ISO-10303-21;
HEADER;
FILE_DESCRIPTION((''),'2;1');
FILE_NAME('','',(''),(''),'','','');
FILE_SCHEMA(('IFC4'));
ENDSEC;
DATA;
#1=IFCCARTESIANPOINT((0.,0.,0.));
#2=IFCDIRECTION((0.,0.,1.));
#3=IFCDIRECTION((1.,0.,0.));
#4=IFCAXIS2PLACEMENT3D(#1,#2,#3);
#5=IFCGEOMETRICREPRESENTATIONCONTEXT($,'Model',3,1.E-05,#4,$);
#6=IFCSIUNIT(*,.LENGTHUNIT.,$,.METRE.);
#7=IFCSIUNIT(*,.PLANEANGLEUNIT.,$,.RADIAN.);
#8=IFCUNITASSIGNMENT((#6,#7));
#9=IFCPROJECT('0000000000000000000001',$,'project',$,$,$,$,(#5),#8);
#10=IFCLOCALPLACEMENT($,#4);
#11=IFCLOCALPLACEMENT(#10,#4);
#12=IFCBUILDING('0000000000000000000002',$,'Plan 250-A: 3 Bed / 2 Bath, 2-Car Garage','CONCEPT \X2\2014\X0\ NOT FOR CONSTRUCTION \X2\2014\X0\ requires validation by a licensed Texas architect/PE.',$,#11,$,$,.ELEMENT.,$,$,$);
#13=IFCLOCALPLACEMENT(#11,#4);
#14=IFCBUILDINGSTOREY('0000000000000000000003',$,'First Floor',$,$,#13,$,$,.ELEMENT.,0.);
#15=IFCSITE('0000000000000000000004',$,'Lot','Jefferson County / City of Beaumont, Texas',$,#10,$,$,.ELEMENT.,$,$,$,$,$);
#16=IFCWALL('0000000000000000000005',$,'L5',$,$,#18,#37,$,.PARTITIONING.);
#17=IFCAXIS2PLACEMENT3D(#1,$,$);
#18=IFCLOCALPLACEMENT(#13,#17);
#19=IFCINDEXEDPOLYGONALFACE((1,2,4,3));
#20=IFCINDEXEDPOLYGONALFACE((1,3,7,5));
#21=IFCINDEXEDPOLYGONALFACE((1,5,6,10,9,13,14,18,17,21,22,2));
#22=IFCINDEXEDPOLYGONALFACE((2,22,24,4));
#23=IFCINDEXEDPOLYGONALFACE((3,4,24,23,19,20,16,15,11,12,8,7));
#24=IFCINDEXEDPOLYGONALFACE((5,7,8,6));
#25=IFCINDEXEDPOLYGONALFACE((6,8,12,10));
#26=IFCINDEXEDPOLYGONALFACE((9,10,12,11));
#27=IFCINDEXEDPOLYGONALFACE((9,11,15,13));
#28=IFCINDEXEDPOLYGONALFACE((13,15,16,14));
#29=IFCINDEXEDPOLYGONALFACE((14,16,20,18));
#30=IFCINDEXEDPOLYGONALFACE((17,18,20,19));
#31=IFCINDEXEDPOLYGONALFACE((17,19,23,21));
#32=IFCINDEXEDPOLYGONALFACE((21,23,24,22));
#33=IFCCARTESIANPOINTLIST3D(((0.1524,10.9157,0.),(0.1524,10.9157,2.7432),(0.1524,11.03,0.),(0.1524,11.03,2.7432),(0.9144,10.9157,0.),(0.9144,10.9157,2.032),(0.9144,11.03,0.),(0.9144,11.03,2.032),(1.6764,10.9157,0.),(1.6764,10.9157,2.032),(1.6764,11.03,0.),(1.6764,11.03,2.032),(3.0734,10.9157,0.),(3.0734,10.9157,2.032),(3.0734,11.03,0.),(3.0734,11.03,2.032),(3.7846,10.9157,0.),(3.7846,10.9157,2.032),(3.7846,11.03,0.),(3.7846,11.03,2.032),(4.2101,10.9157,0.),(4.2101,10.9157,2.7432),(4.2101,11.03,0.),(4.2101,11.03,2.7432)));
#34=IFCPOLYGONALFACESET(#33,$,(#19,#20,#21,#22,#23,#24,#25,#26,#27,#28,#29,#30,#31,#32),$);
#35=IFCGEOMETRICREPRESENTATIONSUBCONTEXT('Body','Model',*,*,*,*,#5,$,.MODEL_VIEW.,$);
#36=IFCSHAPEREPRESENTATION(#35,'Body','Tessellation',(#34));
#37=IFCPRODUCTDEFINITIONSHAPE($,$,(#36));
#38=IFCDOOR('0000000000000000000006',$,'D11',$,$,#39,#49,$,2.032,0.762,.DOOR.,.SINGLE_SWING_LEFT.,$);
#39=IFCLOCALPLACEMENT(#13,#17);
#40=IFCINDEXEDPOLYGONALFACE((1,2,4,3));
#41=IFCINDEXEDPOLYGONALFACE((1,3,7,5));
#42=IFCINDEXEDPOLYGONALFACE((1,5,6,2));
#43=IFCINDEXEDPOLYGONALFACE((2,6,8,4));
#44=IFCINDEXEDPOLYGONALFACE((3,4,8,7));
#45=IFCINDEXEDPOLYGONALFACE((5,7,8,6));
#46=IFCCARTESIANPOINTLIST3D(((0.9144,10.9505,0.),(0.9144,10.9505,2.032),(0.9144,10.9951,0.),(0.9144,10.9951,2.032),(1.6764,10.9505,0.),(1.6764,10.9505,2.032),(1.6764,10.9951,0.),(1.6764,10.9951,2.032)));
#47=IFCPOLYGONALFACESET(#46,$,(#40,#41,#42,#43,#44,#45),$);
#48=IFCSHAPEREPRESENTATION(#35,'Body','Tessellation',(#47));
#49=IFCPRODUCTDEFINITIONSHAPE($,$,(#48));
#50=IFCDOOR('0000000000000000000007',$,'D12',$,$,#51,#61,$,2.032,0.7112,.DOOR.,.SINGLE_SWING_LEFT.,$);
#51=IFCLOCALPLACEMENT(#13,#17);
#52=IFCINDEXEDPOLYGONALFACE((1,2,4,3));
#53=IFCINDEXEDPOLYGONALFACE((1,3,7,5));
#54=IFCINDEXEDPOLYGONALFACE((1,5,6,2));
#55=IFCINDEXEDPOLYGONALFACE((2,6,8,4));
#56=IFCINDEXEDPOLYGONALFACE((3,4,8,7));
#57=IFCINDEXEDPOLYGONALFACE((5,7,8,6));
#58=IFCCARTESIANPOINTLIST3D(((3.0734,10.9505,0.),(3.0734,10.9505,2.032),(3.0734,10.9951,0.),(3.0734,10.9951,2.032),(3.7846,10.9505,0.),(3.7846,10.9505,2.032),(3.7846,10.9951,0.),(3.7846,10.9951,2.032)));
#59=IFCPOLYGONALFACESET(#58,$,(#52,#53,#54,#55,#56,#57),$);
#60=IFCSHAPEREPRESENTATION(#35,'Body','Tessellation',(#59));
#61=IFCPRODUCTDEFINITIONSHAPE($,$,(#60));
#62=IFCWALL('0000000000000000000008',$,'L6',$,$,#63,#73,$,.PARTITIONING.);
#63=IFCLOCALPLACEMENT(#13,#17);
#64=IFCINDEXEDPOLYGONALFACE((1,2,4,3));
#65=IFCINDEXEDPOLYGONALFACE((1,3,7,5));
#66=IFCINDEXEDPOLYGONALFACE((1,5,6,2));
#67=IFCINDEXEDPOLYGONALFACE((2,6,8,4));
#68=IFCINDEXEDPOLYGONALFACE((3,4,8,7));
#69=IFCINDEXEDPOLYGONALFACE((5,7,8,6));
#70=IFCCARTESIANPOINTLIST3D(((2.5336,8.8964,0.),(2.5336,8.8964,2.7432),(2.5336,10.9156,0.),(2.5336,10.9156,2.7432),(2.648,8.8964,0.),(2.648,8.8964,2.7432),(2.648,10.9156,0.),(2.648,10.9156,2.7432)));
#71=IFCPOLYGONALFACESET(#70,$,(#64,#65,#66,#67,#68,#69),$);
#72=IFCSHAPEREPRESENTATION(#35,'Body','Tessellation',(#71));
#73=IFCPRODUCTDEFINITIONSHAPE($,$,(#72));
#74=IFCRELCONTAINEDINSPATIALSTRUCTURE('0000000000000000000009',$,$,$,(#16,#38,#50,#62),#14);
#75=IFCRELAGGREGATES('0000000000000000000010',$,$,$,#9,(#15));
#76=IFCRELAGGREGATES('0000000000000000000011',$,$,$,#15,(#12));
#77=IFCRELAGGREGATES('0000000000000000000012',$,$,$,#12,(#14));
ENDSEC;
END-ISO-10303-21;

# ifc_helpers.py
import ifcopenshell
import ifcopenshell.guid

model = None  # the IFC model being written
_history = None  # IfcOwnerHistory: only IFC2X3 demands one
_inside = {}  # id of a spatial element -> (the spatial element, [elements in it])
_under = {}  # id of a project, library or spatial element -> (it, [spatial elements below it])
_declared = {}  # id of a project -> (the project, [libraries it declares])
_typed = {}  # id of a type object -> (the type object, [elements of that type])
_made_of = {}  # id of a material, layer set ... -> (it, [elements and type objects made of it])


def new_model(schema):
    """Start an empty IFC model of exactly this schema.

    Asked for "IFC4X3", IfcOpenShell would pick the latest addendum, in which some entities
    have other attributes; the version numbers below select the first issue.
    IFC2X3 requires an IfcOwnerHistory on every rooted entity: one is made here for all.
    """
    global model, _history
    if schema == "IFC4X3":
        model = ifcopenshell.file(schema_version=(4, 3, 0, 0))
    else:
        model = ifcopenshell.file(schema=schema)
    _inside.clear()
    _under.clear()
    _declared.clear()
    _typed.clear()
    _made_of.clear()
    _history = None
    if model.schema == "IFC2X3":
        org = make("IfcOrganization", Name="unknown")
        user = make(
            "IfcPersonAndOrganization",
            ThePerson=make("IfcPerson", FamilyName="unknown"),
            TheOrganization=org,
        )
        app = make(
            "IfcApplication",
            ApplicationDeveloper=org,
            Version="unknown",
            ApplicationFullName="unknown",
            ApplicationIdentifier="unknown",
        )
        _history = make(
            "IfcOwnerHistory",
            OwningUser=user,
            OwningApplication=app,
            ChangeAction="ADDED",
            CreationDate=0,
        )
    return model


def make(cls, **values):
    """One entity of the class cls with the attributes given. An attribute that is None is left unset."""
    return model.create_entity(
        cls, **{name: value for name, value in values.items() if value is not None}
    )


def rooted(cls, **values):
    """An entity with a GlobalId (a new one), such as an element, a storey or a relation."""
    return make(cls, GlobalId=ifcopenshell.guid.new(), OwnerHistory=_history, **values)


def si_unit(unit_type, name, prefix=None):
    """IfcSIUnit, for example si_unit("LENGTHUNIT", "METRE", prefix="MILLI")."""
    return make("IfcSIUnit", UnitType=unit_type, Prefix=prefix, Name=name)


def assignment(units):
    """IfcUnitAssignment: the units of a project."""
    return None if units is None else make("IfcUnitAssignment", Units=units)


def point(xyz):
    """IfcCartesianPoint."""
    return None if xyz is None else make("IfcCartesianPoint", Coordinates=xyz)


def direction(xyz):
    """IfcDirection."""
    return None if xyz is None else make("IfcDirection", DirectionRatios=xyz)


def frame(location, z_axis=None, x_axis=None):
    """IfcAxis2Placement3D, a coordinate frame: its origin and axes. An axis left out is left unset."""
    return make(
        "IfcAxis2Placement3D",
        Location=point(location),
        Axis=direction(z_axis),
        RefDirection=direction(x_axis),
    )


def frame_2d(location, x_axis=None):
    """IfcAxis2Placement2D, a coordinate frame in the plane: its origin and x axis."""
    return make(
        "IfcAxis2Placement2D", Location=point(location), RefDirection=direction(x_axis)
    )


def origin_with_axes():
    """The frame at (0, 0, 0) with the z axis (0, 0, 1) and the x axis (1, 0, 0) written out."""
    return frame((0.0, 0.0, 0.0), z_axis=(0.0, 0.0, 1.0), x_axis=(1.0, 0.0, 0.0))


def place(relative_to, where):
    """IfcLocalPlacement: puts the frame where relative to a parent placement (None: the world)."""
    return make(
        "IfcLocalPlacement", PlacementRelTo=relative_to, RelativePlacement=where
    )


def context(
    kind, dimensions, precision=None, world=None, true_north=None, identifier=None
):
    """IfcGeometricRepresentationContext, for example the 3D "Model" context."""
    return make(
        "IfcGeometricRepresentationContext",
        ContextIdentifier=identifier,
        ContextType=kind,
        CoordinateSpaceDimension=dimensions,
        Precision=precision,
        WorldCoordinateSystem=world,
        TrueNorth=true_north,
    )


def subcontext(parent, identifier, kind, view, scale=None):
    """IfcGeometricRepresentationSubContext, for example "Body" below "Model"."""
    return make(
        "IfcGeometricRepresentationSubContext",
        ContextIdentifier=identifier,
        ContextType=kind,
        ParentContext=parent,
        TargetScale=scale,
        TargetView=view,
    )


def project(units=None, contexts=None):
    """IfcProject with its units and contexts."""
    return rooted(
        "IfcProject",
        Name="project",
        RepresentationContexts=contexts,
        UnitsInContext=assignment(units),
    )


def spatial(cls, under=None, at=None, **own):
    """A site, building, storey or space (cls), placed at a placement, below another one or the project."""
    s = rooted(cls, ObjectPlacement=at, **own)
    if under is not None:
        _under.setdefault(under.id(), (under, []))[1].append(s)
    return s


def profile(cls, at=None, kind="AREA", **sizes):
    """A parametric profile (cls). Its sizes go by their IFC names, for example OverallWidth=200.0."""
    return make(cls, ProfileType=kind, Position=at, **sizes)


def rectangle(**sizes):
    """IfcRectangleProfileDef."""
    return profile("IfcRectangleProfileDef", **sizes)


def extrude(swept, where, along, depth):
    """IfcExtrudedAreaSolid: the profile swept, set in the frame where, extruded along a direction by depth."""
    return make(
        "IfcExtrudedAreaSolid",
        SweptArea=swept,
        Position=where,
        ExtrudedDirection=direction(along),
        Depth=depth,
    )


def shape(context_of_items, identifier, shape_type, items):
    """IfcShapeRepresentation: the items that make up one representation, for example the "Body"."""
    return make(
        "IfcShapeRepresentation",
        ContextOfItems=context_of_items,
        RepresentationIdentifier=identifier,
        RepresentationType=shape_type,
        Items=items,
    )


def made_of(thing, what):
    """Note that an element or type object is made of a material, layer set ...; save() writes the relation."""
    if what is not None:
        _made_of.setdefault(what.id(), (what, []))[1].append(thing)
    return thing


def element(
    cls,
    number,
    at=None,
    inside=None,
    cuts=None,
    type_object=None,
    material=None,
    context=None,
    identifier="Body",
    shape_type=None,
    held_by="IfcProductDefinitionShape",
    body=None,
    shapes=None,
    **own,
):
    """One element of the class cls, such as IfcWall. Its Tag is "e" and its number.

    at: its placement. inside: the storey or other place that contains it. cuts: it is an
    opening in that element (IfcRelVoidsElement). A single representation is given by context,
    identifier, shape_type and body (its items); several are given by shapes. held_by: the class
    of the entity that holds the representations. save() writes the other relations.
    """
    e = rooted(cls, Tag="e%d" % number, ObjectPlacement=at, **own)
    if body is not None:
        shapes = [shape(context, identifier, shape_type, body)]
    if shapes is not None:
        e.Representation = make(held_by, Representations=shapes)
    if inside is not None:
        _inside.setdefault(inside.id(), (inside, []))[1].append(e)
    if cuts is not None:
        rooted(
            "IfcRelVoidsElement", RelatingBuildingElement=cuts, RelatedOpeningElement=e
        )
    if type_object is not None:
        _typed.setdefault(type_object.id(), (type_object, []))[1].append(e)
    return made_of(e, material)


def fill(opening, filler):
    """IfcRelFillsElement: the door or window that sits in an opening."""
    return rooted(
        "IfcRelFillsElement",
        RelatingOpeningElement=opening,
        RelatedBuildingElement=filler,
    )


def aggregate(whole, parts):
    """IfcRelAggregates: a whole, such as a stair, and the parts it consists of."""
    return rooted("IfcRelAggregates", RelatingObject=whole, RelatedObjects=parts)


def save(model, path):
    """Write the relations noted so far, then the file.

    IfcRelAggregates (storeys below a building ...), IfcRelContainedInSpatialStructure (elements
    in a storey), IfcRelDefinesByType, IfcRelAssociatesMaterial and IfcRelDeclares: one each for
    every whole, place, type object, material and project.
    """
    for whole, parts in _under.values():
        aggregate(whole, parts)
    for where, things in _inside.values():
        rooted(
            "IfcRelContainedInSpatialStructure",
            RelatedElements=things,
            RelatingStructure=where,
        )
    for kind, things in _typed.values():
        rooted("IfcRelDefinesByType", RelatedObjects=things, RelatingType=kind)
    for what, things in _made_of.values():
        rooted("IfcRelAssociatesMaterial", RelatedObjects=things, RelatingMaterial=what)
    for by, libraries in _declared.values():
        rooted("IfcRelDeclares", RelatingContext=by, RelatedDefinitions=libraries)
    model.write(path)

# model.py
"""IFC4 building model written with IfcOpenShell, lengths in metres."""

from ifc_helpers import new_model, si_unit, frame, frame_2d, origin_with_axes, place, context, subcontext, project, spatial, rectangle, extrude, element, fill, save


model = new_model("IFC4")

# Units and contexts
model_context = context("Model", 3, precision=1e-05, world=origin_with_axes())
body_context = subcontext(model_context, "Body", "Model", "MODEL_VIEW")
ifc_project = project(units=[si_unit("LENGTHUNIT", "METRE"), si_unit("PLANEANGLEUNIT", "RADIAN")], contexts=[model_context])

# Site, building, storey
site_placement = place(None, origin_with_axes())
site = spatial("IfcSite", under=ifc_project, at=site_placement, Name="Lot", Description="Jefferson County / City of Beaumont, Texas", CompositionType="ELEMENT")
building_placement = place(site_placement, origin_with_axes())
building = spatial("IfcBuilding", under=site, at=building_placement, Name="Plan 250-A: 3 Bed / 2 Bath, 2-Car Garage", Description="CONCEPT — NOT FOR CONSTRUCTION — requires validation by a licensed Texas architect/PE.", CompositionType="ELEMENT")
storey_placement = place(building_placement, origin_with_axes())
storey = spatial("IfcBuildingStorey", under=building, at=storey_placement, Name="First Floor", CompositionType="ELEMENT", Elevation=0.0)

# Wall, openings, doors
wall_1_placement = place(storey_placement, frame((0.1524, 10.9728, 0.0), z_axis=(0.0, 0.0, 1.0), x_axis=(1.0, 0.0, 0.0)))
wall_1 = element("IfcWall", 1, at=wall_1_placement, inside=storey, Name="L5", PredefinedType="PARTITIONING", context=body_context, shape_type="SweptSolid", body=[
    extrude(rectangle(XDim=4.0577, YDim=0.1143, at=frame_2d((2.0288, 0.0), x_axis=(1.0, 0.0))), origin_with_axes(), (0.0, 0.0, 1.0), 2.7432),
])
opening_1_placement = place(wall_1_placement, frame((0.762, 0.0, 0.0), z_axis=(0.0, 0.0, 1.0), x_axis=(1.0, 0.0, 0.0)))
opening_1 = element("IfcOpeningElement", 2, at=opening_1_placement, cuts=wall_1, PredefinedType="OPENING", context=body_context, shape_type="SweptSolid", body=[
    extrude(rectangle(XDim=0.762, YDim=0.1448, at=frame_2d((0.381, 0.0), x_axis=(1.0, 0.0))), origin_with_axes(), (0.0, 0.0, 1.0), 2.032),
])
opening_2_placement = place(wall_1_placement, frame((2.921, 0.0, 0.0), z_axis=(0.0, 0.0, 1.0), x_axis=(1.0, 0.0, 0.0)))
opening_2 = element("IfcOpeningElement", 3, at=opening_2_placement, cuts=wall_1, PredefinedType="OPENING", context=body_context, shape_type="SweptSolid", body=[
    extrude(rectangle(XDim=0.7112, YDim=0.1448, at=frame_2d((0.3556, 0.0), x_axis=(1.0, 0.0))), origin_with_axes(), (0.0, 0.0, 1.0), 2.032),
])
door_1_placement = place(opening_1_placement, origin_with_axes())
door_1 = element("IfcDoor", 4, at=door_1_placement, inside=storey, Name="D11", OperationType="SINGLE_SWING_LEFT", OverallHeight=2.032, OverallWidth=0.762, PredefinedType="DOOR", context=body_context, shape_type="SweptSolid", body=[
    extrude(rectangle(XDim=0.762, YDim=0.0445, at=frame_2d((0.381, 0.0), x_axis=(1.0, 0.0))), origin_with_axes(), (0.0, 0.0, 1.0), 2.032),
])
fill(opening_1, door_1)
door_2_placement = place(opening_2_placement, origin_with_axes())
door_2 = element("IfcDoor", 5, at=door_2_placement, inside=storey, Name="D12", OperationType="SINGLE_SWING_LEFT", OverallHeight=2.032, OverallWidth=0.7112, PredefinedType="DOOR", context=body_context, shape_type="SweptSolid", body=[
    extrude(rectangle(XDim=0.7112, YDim=0.0445, at=frame_2d((0.3556, 0.0), x_axis=(1.0, 0.0))), origin_with_axes(), (0.0, 0.0, 1.0), 2.032),
])
fill(opening_2, door_2)

# Wall
wall_2_placement = place(storey_placement, frame((2.5908, 8.8963, 0.0), z_axis=(0.0, 0.0, 1.0), x_axis=(0.0, 1.0, 0.0)))
element("IfcWall", 6, at=wall_2_placement, inside=storey, Name="L6", PredefinedType="PARTITIONING", context=body_context, shape_type="SweptSolid", body=[
    extrude(rectangle(XDim=2.0193, YDim=0.1143, at=frame_2d((1.0097, 0.0), x_axis=(1.0, 0.0))), origin_with_axes(), (0.0, 0.0, 1.0), 2.7432),
])

save(model, "model.ifc")
